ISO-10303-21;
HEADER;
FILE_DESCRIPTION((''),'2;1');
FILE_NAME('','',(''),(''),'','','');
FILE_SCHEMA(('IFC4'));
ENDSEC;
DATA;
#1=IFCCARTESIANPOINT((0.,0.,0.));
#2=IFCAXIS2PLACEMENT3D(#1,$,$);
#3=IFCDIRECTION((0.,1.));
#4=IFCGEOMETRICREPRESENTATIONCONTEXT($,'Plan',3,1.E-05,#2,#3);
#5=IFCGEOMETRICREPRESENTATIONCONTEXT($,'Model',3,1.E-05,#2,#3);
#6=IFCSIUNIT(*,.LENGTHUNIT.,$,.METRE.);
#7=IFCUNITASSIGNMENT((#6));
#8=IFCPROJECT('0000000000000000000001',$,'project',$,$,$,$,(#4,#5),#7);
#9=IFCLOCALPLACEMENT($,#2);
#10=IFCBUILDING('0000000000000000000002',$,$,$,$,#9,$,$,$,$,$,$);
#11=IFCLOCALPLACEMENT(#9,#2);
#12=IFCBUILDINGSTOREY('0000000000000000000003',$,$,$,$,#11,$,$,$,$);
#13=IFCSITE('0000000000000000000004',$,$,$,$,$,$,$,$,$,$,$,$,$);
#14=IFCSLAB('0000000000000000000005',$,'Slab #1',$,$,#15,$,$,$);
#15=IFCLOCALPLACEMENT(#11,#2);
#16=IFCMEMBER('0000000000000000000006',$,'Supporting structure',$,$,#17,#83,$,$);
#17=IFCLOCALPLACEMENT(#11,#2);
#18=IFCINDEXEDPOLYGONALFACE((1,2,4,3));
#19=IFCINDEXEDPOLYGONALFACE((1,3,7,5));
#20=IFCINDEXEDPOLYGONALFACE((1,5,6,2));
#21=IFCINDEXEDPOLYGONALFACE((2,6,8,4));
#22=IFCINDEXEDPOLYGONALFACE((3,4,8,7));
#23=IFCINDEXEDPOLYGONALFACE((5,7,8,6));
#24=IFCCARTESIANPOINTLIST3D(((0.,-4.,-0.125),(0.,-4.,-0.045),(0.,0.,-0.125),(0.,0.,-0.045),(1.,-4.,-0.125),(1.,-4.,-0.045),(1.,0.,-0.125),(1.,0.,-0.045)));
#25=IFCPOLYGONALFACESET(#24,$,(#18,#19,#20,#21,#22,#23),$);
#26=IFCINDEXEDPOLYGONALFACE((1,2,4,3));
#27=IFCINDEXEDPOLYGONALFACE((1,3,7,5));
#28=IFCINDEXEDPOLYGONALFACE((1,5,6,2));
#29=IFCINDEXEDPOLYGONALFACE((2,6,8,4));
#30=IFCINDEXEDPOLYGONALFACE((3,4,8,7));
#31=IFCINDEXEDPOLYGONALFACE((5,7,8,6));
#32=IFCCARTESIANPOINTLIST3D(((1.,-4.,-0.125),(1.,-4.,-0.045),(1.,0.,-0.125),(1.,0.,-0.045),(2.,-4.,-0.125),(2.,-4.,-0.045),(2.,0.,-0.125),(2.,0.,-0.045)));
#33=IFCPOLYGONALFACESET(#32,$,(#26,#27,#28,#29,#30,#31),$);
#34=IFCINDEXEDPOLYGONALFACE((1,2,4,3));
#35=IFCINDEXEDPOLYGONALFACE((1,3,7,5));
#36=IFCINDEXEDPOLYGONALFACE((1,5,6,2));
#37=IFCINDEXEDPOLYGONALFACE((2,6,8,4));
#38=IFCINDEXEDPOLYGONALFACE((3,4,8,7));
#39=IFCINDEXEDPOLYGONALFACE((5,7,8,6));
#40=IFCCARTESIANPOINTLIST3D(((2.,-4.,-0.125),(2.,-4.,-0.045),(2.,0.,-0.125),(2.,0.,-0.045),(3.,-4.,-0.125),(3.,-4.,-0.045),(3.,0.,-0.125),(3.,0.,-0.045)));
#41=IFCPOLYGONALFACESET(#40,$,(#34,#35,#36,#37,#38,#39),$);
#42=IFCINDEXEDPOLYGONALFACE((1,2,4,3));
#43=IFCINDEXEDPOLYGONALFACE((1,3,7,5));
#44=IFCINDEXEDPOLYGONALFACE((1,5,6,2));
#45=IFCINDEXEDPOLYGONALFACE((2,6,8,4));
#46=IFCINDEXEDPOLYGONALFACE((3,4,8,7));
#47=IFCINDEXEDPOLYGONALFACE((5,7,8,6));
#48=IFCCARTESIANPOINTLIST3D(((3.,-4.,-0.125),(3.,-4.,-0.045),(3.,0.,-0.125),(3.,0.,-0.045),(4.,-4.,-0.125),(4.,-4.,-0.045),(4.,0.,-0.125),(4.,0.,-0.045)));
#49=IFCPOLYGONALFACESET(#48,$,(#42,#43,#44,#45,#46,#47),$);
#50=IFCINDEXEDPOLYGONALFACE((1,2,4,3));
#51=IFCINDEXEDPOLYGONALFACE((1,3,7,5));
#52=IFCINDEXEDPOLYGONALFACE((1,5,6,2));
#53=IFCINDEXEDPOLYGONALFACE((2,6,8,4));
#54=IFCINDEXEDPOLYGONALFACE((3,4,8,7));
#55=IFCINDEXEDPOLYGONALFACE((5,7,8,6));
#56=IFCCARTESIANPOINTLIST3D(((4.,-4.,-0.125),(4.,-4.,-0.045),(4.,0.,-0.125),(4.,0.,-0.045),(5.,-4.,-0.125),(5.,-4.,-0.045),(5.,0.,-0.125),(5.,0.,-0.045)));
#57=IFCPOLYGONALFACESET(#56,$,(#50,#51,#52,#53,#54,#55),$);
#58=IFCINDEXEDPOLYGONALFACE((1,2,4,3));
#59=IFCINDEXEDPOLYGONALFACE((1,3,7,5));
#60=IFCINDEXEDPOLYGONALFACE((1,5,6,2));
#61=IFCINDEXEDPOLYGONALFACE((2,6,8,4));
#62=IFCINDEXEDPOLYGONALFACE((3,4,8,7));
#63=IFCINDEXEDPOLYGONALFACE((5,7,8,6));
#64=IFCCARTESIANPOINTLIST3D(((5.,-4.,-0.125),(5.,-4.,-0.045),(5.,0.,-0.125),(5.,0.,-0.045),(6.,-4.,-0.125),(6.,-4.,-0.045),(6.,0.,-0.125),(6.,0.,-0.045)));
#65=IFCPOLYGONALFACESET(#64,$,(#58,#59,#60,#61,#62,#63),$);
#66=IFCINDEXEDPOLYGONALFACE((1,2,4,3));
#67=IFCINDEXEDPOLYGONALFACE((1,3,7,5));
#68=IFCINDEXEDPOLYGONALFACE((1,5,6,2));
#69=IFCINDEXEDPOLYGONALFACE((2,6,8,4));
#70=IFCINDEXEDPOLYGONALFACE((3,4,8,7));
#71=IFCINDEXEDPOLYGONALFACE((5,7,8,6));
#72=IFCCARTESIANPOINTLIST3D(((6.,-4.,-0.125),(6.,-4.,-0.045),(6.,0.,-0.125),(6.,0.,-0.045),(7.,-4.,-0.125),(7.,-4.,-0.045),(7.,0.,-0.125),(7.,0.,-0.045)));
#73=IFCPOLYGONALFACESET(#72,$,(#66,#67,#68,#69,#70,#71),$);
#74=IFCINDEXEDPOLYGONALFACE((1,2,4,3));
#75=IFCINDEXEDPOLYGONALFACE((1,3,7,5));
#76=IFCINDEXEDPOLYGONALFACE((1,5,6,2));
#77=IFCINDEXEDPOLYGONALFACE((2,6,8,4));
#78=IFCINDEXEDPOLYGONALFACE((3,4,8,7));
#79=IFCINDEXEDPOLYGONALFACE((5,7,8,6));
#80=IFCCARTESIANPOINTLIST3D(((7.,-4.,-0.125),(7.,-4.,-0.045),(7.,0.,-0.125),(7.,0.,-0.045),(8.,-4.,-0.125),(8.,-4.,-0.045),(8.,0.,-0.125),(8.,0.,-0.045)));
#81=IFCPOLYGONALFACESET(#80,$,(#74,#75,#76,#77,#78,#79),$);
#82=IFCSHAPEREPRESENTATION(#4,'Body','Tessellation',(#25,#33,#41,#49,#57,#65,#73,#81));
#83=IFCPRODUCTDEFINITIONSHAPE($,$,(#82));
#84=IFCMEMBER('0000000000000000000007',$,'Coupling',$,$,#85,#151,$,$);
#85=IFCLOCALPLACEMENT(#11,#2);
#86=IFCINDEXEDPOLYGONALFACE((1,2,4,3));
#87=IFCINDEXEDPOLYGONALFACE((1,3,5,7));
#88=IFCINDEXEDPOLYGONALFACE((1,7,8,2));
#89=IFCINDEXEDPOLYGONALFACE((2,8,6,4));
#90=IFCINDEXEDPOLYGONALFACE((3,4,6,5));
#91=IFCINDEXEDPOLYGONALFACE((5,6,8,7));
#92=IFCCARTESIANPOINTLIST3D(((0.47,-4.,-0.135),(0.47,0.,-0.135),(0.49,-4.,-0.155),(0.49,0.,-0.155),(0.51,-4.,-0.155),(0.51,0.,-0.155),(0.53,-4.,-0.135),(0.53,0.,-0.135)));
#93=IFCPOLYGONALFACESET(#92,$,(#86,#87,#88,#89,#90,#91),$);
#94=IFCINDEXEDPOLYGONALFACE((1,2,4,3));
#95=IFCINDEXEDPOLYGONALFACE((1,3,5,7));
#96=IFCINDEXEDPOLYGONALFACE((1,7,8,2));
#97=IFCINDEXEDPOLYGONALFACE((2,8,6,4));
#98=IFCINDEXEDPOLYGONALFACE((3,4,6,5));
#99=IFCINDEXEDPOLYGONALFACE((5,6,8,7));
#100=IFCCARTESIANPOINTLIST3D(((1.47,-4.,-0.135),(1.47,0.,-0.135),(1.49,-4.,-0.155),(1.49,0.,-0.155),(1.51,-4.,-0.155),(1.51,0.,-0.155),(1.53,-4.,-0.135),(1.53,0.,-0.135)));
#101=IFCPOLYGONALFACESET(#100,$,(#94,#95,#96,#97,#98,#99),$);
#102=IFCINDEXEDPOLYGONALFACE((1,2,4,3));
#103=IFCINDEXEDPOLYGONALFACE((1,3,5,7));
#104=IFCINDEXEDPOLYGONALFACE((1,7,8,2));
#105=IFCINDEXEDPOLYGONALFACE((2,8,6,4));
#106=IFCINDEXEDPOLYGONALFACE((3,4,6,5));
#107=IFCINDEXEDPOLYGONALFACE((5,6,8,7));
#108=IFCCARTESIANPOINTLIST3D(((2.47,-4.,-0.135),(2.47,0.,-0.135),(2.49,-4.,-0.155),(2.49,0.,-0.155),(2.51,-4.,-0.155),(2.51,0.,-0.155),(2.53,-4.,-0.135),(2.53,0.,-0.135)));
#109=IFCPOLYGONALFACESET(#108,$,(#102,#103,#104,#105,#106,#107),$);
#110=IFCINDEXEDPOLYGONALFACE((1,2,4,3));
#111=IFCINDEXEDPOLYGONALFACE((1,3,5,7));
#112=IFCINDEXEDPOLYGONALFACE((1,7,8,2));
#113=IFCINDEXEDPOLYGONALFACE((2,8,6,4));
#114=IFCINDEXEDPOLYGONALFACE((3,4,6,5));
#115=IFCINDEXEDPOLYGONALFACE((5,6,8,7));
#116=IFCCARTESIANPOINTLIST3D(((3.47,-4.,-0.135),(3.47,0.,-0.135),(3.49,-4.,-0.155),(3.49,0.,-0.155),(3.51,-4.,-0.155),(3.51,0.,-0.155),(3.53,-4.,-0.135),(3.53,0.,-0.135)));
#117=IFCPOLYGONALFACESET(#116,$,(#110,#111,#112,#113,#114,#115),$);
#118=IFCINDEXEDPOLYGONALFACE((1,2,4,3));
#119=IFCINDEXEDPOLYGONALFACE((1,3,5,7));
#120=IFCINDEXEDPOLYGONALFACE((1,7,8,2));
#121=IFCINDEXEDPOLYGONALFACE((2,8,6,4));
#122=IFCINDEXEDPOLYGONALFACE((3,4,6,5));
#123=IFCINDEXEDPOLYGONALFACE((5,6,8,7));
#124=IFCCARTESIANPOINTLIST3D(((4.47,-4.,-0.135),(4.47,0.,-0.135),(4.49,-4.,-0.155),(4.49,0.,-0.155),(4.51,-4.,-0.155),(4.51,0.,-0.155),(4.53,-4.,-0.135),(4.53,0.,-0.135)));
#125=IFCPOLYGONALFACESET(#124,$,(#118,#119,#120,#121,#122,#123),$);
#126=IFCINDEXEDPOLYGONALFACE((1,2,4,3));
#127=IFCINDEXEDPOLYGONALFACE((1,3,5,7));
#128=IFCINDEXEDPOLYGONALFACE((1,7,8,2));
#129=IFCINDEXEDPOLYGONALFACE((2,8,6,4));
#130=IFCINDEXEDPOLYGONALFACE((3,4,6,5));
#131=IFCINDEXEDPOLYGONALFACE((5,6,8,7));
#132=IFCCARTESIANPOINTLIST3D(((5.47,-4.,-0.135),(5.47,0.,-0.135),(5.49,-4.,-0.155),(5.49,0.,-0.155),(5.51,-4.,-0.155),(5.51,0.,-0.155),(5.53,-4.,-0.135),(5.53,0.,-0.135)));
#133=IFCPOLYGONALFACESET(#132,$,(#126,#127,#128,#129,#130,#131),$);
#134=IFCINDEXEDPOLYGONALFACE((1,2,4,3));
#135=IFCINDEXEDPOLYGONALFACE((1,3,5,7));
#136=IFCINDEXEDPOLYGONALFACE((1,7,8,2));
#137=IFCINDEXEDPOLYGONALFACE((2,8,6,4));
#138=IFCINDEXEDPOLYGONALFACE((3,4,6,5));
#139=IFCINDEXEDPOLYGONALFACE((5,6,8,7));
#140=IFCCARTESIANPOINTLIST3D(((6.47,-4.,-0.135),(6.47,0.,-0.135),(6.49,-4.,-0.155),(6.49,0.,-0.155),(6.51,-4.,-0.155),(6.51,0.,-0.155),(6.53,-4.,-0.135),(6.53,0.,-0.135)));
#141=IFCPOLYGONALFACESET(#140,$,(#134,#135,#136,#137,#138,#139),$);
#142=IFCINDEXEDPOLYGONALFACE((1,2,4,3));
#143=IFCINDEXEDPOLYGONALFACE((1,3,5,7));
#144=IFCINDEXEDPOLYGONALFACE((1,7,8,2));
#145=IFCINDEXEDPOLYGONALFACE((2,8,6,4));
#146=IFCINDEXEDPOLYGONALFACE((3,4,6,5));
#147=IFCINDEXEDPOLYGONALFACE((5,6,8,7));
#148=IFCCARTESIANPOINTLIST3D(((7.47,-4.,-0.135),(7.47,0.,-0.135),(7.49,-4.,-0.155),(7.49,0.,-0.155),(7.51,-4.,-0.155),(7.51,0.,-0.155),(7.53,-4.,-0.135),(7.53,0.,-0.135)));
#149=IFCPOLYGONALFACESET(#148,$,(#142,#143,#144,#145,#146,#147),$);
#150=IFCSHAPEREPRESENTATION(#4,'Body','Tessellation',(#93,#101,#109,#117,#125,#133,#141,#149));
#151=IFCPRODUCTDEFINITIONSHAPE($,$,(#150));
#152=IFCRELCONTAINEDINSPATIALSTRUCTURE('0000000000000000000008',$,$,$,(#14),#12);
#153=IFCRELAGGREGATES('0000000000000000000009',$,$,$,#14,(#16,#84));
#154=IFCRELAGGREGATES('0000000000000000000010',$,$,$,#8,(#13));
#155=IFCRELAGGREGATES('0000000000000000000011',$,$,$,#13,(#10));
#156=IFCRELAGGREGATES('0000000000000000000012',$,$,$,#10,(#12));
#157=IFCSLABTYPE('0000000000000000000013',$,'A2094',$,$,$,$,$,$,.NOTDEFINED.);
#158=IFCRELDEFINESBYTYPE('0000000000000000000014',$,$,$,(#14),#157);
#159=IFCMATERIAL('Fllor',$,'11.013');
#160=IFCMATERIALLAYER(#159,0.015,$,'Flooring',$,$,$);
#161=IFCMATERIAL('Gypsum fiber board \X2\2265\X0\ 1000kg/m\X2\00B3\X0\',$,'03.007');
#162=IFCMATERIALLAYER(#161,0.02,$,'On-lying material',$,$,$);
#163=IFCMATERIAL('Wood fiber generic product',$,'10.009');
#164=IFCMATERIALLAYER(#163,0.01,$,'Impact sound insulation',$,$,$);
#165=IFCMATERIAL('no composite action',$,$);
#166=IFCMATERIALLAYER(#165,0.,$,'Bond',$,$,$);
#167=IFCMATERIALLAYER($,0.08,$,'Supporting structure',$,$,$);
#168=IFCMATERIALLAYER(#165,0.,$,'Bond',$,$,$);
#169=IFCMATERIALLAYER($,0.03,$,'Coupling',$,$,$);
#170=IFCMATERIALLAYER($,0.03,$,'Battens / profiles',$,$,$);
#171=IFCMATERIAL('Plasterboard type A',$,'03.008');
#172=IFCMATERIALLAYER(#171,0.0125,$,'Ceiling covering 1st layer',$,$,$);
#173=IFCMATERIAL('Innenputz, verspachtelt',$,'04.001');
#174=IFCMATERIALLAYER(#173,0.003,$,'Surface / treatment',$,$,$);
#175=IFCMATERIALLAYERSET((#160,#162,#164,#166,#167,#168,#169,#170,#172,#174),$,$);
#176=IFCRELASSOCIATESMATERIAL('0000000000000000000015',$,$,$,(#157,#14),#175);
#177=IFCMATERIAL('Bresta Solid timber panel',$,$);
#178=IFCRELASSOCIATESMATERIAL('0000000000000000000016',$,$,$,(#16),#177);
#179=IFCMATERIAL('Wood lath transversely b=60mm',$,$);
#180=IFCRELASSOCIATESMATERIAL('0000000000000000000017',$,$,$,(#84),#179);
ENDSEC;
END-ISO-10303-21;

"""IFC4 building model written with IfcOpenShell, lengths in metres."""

from ifc_helpers import new_model, si_unit, direction, frame, frame_2d, origin, place, context, project, spatial, polyline, rectangle, outline, extrude, material, layer, layer_set, type_object, element, aggregate, save


model = new_model("IFC4")

# Units and contexts
plan_context = context("Plan", 3, precision=1e-05, world=origin(), true_north=direction((0.0, 1.0)))
model_context = context("Model", 3, precision=1e-05, world=origin(), true_north=direction((0.0, 1.0)))
ifc_project = project(units=[si_unit("LENGTHUNIT", "METRE")], contexts=[plan_context, model_context])

# Site, building, storey
site = spatial("IfcSite", under=ifc_project)
building_placement = place(None, origin())
building = spatial("IfcBuilding", under=site, at=building_placement)
storey_placement = place(building_placement, origin())
storey = spatial("IfcBuildingStorey", under=building, at=storey_placement)

# Slab, members
ifc_material_1 = material(Name="Fllor", Category="11.013")
ifc_layer_1 = layer(ifc_material_1, 0.015, Name="Flooring")
ifc_material_2 = material(Name="Gypsum fiber board ≥ 1000kg/m³", Category="03.007")
ifc_layer_2 = layer(ifc_material_2, 0.02, Name="On-lying material")
ifc_material_3 = material(Name="Wood fiber generic product", Category="10.009")
ifc_layer_3 = layer(ifc_material_3, 0.01, Name="Impact sound insulation")
ifc_material_4 = material(Name="no composite action")
ifc_layer_4 = layer(ifc_material_4, 0.0, Name="Bond")
ifc_layer_5 = layer(None, 0.08, Name="Supporting structure")
ifc_layer_6 = layer(ifc_material_4, 0.0, Name="Bond")
ifc_layer_7 = layer(None, 0.03, Name="Coupling")
ifc_layer_8 = layer(None, 0.03, Name="Battens / profiles")
ifc_material_5 = material(Name="Plasterboard type A", Category="03.008")
ifc_layer_9 = layer(ifc_material_5, 0.0125, Name="Ceiling covering 1st layer")
ifc_material_6 = material(Name="Innenputz, verspachtelt", Category="04.001")
ifc_layer_10 = layer(ifc_material_6, 0.003, Name="Surface / treatment")
ifc_layer_set = layer_set([ifc_layer_1, ifc_layer_2, ifc_layer_3, ifc_layer_4, ifc_layer_5, ifc_layer_6, ifc_layer_7, ifc_layer_8, ifc_layer_9, ifc_layer_10])
slab_type = type_object("IfcSlabType", Name="A2094", PredefinedType="NOTDEFINED", material=ifc_layer_set)
slab_placement = place(None, frame((0.0, 0.0, 0.0), z_axis=(0.0, 0.0, -1.0), x_axis=(1.0, 0.0, 0.0)))
slab = element("IfcSlab", 1, at=slab_placement, inside=storey, type_object=slab_type, material=ifc_layer_set, Name="Slab #1")
ifc_material_7 = material(Name="Bresta Solid timber panel")
member_1_placement = place(slab_placement, origin())
member_1 = element("IfcMember", 2, at=member_1_placement, material=ifc_material_7, Name="Supporting structure", context=plan_context, shape_type="SweptSolid", body=[
    extrude(rectangle(XDim=1.0, YDim=0.08, at=frame_2d((0.5, 0.04), x_axis=(1.0, 0.0))), frame((0.0, 4.0, 0.045), z_axis=(0.0, -1.0, 0.0), x_axis=(1.0, 0.0, 0.0)), (0.0, 0.0, 1.0), 4.0),
    extrude(rectangle(XDim=1.0, YDim=0.08, at=frame_2d((0.5, 0.04), x_axis=(1.0, 0.0))), frame((1.0, 4.0, 0.045), z_axis=(0.0, -1.0, 0.0), x_axis=(1.0, 0.0, 0.0)), (0.0, 0.0, 1.0), 4.0),
    extrude(rectangle(XDim=1.0, YDim=0.08, at=frame_2d((0.5, 0.04), x_axis=(1.0, 0.0))), frame((2.0, 4.0, 0.045), z_axis=(0.0, -1.0, 0.0), x_axis=(1.0, 0.0, 0.0)), (0.0, 0.0, 1.0), 4.0),
    extrude(rectangle(XDim=1.0, YDim=0.08, at=frame_2d((0.5, 0.04), x_axis=(1.0, 0.0))), frame((3.0, 4.0, 0.045), z_axis=(0.0, -1.0, 0.0), x_axis=(1.0, 0.0, 0.0)), (0.0, 0.0, 1.0), 4.0),
    extrude(rectangle(XDim=1.0, YDim=0.08, at=frame_2d((0.5, 0.04), x_axis=(1.0, 0.0))), frame((4.0, 4.0, 0.045), z_axis=(0.0, -1.0, 0.0), x_axis=(1.0, 0.0, 0.0)), (0.0, 0.0, 1.0), 4.0),
    extrude(rectangle(XDim=1.0, YDim=0.08, at=frame_2d((0.5, 0.04), x_axis=(1.0, 0.0))), frame((5.0, 4.0, 0.045), z_axis=(0.0, -1.0, 0.0), x_axis=(1.0, 0.0, 0.0)), (0.0, 0.0, 1.0), 4.0),
    extrude(rectangle(XDim=1.0, YDim=0.08, at=frame_2d((0.5, 0.04), x_axis=(1.0, 0.0))), frame((6.0, 4.0, 0.045), z_axis=(0.0, -1.0, 0.0), x_axis=(1.0, 0.0, 0.0)), (0.0, 0.0, 1.0), 4.0),
    extrude(rectangle(XDim=1.0, YDim=0.08, at=frame_2d((0.5, 0.04), x_axis=(1.0, 0.0))), frame((7.0, 4.0, 0.045), z_axis=(0.0, -1.0, 0.0), x_axis=(1.0, 0.0, 0.0)), (0.0, 0.0, 1.0), 4.0),
])
ifc_material_8 = material(Name="Wood lath transversely b=60mm")
member_2_placement = place(slab_placement, origin())
member_2 = element("IfcMember", 3, at=member_2_placement, material=ifc_material_8, Name="Coupling", context=plan_context, shape_type="SweptSolid", body=[
    extrude(outline(polyline([(0.0, 0.0), (0.06, 0.0), (0.04, 0.02), (0.02, 0.02), (0.0, 0.0)])), frame((0.47, 4.0, 0.135), z_axis=(0.0, -1.0, 0.0), x_axis=(1.0, 0.0, 0.0)), (0.0, 0.0, 1.0), 4.0),
    extrude(outline(polyline([(0.0, 0.0), (0.06, 0.0), (0.04, 0.02), (0.02, 0.02), (0.0, 0.0)])), frame((1.47, 4.0, 0.135), z_axis=(0.0, -1.0, 0.0), x_axis=(1.0, 0.0, 0.0)), (0.0, 0.0, 1.0), 4.0),
    extrude(outline(polyline([(0.0, 0.0), (0.06, 0.0), (0.04, 0.02), (0.02, 0.02), (0.0, 0.0)])), frame((2.47, 4.0, 0.135), z_axis=(0.0, -1.0, 0.0), x_axis=(1.0, 0.0, 0.0)), (0.0, 0.0, 1.0), 4.0),
    extrude(outline(polyline([(0.0, 0.0), (0.06, 0.0), (0.04, 0.02), (0.02, 0.02), (0.0, 0.0)])), frame((3.47, 4.0, 0.135), z_axis=(0.0, -1.0, 0.0), x_axis=(1.0, 0.0, 0.0)), (0.0, 0.0, 1.0), 4.0),
    extrude(outline(polyline([(0.0, 0.0), (0.06, 0.0), (0.04, 0.02), (0.02, 0.02), (0.0, 0.0)])), frame((4.47, 4.0, 0.135), z_axis=(0.0, -1.0, 0.0), x_axis=(1.0, 0.0, 0.0)), (0.0, 0.0, 1.0), 4.0),
    extrude(outline(polyline([(0.0, 0.0), (0.06, 0.0), (0.04, 0.02), (0.02, 0.02), (0.0, 0.0)])), frame((5.47, 4.0, 0.135), z_axis=(0.0, -1.0, 0.0), x_axis=(1.0, 0.0, 0.0)), (0.0, 0.0, 1.0), 4.0),
    extrude(outline(polyline([(0.0, 0.0), (0.06, 0.0), (0.04, 0.02), (0.02, 0.02), (0.0, 0.0)])), frame((6.47, 4.0, 0.135), z_axis=(0.0, -1.0, 0.0), x_axis=(1.0, 0.0, 0.0)), (0.0, 0.0, 1.0), 4.0),
    extrude(outline(polyline([(0.0, 0.0), (0.06, 0.0), (0.04, 0.02), (0.02, 0.02), (0.0, 0.0)])), frame((7.47, 4.0, 0.135), z_axis=(0.0, -1.0, 0.0), x_axis=(1.0, 0.0, 0.0)), (0.0, 0.0, 1.0), 4.0),
])
aggregate(slab, [member_1, member_2])

save(model, "model.ifc")
